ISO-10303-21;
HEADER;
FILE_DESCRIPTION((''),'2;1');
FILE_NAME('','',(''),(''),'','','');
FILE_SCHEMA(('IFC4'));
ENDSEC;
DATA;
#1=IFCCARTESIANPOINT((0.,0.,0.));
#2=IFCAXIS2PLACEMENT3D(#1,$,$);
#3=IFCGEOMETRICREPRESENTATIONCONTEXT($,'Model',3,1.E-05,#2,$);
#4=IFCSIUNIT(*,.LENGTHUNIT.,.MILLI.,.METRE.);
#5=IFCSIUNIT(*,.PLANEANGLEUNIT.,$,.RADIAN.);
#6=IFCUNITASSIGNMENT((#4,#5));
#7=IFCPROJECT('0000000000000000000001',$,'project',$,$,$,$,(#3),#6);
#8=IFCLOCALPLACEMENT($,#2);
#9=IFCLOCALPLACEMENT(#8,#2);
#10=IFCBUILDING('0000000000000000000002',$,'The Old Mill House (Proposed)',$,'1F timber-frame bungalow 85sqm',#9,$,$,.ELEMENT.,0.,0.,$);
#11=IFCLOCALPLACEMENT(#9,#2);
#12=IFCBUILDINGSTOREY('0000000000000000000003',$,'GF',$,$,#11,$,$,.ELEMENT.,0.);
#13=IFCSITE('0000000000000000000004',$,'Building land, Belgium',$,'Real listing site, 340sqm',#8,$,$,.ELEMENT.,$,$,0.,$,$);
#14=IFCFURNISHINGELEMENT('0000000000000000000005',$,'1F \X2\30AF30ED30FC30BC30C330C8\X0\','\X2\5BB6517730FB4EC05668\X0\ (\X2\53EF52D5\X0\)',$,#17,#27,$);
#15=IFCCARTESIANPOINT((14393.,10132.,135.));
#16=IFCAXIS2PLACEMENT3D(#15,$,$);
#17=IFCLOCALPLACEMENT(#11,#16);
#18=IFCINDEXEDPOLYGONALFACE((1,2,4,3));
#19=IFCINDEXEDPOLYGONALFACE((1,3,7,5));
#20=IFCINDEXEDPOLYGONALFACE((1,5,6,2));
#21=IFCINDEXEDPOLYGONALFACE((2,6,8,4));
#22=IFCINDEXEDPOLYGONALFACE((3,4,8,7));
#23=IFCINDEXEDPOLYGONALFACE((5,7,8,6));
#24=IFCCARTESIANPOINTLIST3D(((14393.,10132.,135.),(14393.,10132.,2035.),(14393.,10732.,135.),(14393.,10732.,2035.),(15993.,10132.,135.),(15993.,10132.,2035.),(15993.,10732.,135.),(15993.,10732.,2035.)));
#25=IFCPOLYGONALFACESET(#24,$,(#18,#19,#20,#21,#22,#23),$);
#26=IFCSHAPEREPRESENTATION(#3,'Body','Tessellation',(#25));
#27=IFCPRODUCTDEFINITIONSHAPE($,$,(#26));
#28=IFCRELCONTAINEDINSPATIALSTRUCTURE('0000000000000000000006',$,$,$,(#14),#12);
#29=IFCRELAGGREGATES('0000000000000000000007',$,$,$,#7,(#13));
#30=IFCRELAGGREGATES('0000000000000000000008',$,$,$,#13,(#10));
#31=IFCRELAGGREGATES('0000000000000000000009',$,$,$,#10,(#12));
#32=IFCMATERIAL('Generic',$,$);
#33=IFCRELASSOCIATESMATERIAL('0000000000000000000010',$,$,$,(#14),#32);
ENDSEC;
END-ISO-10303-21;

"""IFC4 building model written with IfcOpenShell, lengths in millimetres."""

from ifc_helpers import new_model, si_unit, frame, frame_2d, origin, place, context, project, spatial, rectangle, extrude, material, element, save


model = new_model("IFC4")

# Units and contexts
model_context = context("Model", 3, precision=1e-05, world=origin())
ifc_project = project(units=[si_unit("LENGTHUNIT", "METRE", prefix="MILLI"), si_unit("PLANEANGLEUNIT", "RADIAN")], contexts=[model_context])

# Site, building, storey
site_placement = place(None, origin())
site = spatial("IfcSite", under=ifc_project, at=site_placement, Name="Building land, Belgium", ObjectType="Real listing site, 340sqm", CompositionType="ELEMENT", RefElevation=0.0)
building_placement = place(site_placement, origin())
building = spatial("IfcBuilding", under=site, at=building_placement, Name="The Old Mill House (Proposed)", ObjectType="1F timber-frame bungalow 85sqm", CompositionType="ELEMENT", ElevationOfRefHeight=0.0, ElevationOfTerrain=0.0)
storey_placement = place(building_placement, origin())
storey = spatial("IfcBuildingStorey", under=building, at=storey_placement, Name="GF", CompositionType="ELEMENT", Elevation=0.0)

# Shared definitions
ifc_material_1 = material(Name="Generic")

# Furnishing element
furnishing_placement = place(storey_placement, frame((14393.0, 10132.0, 135.0)))
element("IfcFurnishingElement", 1, at=furnishing_placement, inside=storey, material=ifc_material_1, Name="1F クローゼット", Description="家具・什器 (可動)", context=model_context, shape_type="SweptSolid", body=[
    extrude(rectangle(XDim=1600.0, YDim=600.0, at=frame_2d((800.0, 300.0))), frame((14393.0, 10132.0, 135.0)), (0.0, 0.0, 1.0), 1900.0),
])

save(model, "model.ifc")
